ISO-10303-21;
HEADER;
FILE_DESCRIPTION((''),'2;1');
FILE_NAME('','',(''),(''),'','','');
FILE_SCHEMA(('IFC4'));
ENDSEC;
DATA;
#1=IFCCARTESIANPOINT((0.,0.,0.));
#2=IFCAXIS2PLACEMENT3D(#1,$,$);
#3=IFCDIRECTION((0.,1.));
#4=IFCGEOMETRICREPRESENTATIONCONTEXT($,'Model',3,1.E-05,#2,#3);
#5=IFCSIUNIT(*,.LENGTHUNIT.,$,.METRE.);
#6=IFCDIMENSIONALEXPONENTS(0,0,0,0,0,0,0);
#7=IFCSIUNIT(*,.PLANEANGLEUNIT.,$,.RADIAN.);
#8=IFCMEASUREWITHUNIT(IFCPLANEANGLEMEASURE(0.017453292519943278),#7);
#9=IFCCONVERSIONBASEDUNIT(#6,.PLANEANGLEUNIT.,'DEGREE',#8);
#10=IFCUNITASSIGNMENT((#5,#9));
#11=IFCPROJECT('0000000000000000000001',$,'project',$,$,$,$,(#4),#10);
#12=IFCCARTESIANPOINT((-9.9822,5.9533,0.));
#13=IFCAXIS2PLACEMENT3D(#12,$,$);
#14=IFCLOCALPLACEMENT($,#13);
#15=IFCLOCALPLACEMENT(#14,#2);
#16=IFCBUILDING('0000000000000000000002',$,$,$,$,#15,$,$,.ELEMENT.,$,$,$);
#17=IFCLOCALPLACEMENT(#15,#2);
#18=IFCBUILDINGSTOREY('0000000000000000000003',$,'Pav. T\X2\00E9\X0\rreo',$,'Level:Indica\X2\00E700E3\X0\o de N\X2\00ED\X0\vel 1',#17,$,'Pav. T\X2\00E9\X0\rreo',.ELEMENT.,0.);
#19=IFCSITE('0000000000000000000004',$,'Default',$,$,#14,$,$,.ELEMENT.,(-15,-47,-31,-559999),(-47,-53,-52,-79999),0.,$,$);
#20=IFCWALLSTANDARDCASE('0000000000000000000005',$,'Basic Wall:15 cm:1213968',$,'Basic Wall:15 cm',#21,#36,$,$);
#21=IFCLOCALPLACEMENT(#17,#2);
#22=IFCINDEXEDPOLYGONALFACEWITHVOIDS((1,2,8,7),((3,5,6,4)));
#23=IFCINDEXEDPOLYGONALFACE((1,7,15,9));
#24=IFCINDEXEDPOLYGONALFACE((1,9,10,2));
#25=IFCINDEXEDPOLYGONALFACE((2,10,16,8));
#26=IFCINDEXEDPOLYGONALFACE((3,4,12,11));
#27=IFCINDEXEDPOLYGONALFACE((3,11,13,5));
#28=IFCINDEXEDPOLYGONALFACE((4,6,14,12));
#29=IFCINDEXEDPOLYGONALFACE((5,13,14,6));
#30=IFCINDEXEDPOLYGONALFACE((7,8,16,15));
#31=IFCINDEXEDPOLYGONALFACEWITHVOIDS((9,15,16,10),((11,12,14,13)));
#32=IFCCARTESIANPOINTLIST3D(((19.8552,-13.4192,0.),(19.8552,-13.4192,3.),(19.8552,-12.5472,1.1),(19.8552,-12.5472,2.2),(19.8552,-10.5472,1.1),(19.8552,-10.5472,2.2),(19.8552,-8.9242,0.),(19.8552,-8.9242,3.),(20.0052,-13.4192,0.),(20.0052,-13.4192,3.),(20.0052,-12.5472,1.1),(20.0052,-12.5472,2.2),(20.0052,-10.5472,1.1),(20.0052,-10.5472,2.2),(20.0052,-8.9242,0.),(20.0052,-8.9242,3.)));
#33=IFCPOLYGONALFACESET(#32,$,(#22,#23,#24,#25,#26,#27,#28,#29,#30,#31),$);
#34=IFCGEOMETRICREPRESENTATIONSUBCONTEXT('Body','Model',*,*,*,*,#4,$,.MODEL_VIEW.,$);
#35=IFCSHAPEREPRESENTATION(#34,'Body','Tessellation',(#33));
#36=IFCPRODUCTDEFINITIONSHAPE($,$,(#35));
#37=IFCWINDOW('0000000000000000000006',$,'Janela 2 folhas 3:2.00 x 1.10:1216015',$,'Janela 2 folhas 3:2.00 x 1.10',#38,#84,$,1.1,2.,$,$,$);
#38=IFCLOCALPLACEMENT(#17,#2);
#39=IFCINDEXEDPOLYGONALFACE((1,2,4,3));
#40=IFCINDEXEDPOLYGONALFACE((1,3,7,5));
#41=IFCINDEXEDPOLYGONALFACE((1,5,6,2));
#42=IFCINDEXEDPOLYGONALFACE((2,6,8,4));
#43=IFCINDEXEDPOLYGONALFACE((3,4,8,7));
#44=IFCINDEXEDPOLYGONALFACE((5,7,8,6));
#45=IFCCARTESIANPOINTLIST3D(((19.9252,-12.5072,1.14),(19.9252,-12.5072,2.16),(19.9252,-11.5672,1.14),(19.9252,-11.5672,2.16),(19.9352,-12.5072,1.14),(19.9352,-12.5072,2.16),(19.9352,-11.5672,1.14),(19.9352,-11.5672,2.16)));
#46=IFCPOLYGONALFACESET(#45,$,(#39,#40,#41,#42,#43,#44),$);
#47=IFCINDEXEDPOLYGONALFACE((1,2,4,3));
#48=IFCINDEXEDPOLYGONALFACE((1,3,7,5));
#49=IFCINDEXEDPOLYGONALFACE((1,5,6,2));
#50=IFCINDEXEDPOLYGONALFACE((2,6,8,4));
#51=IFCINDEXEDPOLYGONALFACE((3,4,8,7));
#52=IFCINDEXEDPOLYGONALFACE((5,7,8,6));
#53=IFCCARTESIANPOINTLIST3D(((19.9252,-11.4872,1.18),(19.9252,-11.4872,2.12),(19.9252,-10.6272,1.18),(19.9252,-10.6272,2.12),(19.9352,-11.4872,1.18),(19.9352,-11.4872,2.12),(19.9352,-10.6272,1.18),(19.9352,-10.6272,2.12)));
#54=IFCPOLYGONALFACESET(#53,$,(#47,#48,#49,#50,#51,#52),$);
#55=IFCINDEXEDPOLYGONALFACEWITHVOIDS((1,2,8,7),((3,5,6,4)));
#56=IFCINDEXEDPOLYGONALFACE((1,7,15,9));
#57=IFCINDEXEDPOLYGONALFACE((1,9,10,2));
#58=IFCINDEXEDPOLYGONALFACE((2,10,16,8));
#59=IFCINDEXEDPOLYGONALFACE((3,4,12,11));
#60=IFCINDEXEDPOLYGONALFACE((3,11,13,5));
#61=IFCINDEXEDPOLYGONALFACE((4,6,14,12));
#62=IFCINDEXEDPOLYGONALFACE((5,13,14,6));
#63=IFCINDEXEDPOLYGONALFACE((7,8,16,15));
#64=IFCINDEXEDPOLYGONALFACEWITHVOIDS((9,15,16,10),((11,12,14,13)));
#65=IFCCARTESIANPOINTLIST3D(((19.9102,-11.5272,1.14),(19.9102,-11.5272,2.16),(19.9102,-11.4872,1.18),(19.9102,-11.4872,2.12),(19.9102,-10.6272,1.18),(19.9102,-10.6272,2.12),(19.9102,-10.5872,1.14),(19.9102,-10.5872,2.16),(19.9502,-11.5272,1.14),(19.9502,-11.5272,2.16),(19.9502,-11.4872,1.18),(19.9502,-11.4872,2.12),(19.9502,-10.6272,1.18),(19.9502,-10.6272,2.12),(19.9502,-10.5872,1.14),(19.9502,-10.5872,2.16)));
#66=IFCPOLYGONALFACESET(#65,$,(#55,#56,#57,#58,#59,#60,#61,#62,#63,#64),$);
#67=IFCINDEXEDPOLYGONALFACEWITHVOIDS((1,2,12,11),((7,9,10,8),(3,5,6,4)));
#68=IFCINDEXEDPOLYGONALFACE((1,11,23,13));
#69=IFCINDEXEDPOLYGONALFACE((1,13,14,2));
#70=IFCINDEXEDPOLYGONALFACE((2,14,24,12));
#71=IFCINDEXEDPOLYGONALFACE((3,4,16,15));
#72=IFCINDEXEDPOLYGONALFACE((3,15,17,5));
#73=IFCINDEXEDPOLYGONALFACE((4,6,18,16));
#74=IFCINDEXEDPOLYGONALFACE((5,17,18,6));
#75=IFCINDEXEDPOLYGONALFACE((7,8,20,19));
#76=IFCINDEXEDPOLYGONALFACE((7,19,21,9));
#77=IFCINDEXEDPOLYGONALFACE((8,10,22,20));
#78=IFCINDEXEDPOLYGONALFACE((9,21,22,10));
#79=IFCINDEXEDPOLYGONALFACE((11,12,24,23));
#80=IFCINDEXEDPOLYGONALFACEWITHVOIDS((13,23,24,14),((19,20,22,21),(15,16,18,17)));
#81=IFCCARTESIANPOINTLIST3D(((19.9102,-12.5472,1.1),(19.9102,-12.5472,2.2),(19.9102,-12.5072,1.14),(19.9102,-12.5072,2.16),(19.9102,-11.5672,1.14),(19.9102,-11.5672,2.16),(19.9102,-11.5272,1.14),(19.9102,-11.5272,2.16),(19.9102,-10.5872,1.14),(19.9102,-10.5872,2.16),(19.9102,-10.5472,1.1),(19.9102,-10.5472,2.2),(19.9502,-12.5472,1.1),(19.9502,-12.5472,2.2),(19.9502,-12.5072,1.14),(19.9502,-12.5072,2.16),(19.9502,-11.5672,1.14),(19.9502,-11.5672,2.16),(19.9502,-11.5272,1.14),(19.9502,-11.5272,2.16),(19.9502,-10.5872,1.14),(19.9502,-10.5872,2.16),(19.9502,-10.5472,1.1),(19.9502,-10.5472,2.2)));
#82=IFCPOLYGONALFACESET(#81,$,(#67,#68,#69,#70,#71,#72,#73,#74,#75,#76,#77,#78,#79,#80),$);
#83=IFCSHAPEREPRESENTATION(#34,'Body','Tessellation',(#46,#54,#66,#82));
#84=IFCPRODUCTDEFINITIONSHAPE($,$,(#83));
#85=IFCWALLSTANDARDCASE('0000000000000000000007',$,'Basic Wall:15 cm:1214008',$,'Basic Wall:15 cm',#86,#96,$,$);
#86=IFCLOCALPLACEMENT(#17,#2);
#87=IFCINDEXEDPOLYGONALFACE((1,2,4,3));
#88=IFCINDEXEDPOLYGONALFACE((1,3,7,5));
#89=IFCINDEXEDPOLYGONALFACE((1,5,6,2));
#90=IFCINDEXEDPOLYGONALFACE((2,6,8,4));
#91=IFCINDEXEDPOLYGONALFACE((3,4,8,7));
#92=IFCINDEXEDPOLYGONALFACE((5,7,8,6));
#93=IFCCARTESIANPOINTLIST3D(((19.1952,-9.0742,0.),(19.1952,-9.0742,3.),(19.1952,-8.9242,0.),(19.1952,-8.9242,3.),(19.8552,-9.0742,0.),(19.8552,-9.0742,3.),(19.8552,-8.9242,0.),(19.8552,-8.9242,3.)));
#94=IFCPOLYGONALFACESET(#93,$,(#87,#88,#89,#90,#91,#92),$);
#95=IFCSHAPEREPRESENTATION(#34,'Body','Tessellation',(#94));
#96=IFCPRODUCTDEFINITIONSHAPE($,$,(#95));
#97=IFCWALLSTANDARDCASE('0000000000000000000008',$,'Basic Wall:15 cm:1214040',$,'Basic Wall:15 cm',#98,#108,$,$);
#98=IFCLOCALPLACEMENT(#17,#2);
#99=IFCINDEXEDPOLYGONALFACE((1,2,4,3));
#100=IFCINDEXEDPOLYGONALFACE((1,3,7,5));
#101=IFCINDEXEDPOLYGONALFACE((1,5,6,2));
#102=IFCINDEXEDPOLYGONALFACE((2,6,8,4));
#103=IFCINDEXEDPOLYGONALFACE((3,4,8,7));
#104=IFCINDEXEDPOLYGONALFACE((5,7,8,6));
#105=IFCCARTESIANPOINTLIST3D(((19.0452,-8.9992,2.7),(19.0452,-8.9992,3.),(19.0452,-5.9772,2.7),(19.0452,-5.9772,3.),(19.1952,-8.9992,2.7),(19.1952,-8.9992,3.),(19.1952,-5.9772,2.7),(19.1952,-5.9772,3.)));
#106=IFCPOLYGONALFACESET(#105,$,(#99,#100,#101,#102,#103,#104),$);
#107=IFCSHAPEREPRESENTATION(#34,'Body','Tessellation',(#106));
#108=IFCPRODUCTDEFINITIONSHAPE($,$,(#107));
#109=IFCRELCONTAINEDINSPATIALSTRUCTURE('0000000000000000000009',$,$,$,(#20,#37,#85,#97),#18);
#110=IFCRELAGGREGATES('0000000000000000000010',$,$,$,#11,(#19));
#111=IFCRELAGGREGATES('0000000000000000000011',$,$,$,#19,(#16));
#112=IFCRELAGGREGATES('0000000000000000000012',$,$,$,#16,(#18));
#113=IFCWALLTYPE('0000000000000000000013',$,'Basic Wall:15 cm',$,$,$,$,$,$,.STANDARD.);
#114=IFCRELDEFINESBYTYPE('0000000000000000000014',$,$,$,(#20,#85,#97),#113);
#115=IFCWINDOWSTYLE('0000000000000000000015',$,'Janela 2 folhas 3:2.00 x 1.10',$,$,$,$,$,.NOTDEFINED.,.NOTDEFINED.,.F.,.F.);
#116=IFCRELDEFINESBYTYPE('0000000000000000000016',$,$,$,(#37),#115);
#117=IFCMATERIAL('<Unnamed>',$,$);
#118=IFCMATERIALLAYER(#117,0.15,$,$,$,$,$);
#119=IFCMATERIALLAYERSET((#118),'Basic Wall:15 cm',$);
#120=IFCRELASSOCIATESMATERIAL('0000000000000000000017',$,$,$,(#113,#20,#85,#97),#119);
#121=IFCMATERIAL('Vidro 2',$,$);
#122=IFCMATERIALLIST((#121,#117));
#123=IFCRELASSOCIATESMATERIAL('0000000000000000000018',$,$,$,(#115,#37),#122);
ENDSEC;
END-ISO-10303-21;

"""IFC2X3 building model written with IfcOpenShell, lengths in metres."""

from ifc_helpers import new_model, entity, si_unit, converted_unit, direction, frame, frame_2d, origin, origin_2d_with_axis, place, context, subcontext, project, spatial, polyline, rectangle, outline, extrude, source, transform, mapped, material, material_list, layer, layer_set, layer_usage, type_object, type_shapes, element, fill, save


model = new_model("IFC2X3")

# Units and contexts
model_context = context("Model", 3, precision=1e-05, world=origin(), true_north=direction((0.0, 1.0)))
body_context = subcontext(model_context, "Body", "Model", "MODEL_VIEW")
ifc_project = project(units=[si_unit("LENGTHUNIT", "METRE"), converted_unit("PLANEANGLEUNIT", "DEGREE", entity("IfcPlaneAngleMeasure", 0.017453292519943278), si_unit("PLANEANGLEUNIT", "RADIAN"), dimensions=[0, 0, 0, 0, 0, 0, 0])], contexts=[model_context])

# Site, building, storey
site_placement = place(None, frame((-9.9822, 5.9533, 0.0)))
site = spatial("IfcSite", under=ifc_project, at=site_placement, Name="Default", CompositionType="ELEMENT", RefLatitude=(-15, -47, -31, -559999), RefLongitude=(-47, -53, -52, -79999), RefElevation=0.0)
building_placement = place(site_placement, origin())
building = spatial("IfcBuilding", under=site, at=building_placement, CompositionType="ELEMENT")
storey_placement = place(building_placement, origin())
storey = spatial("IfcBuildingStorey", under=building, at=storey_placement, Name="Pav. Térreo", ObjectType="Level:Indicação de Nível 1", LongName="Pav. Térreo", CompositionType="ELEMENT", Elevation=0.0)

# Shared definitions
ifc_material_1 = material(Name="<Unnamed>")

# Shared definitions
ifc_layer = layer(ifc_material_1, 0.15)
ifc_layer_set = layer_set([ifc_layer], Name="Basic Wall:15 cm")
wall_type = type_object("IfcWallType", Name="Basic Wall:15 cm", PredefinedType="STANDARD", material=ifc_layer_set)

# Wall, opening, window
ifc_layer_usage_1 = layer_usage(ifc_layer_set, "AXIS2", "NEGATIVE", 0.075)
wall_1_placement = place(storey_placement, frame((19.9302, -13.4192, 0.0), z_axis=(0.0, 0.0, 1.0), x_axis=(0.0, 1.0, 0.0)))
wall_1 = element("IfcWallStandardCase", 1, at=wall_1_placement, inside=storey, type_object=wall_type, material=ifc_layer_usage_1, Name="Basic Wall:15 cm:1213968", ObjectType="Basic Wall:15 cm", context=body_context, shape_type="SweptSolid", body=[
    extrude(rectangle(XDim=4.495, YDim=0.15, at=frame_2d((2.2475, 0.0), x_axis=(-1.0, 0.0))), origin(), (0.0, 0.0, 1.0), 3.0),
])
opening_placement = place(wall_1_placement, frame((0.872, -0.075, 1.1)))
opening = element("IfcOpeningElement", 2, at=opening_placement, cuts=wall_1, ObjectType="Opening", context=body_context, shape_type="SweptSolid", body=[
    extrude(rectangle(XDim=1.1, YDim=2.0, at=frame_2d((0.55, 1.0), x_axis=(1.0, 0.0))), frame((0.0, 0.0, 0.0), z_axis=(0.0, 1.0, 0.0), x_axis=(0.0, 0.0, 1.0)), (0.0, 0.0, 1.0), 0.15),
])
ifc_material_2 = material(Name="Vidro 2")
ifc_material_list = material_list([ifc_material_2, ifc_material_1])
window_style = type_object("IfcWindowStyle", Name="Janela 2 folhas 3:2.00 x 1.10", ConstructionType="NOTDEFINED", OperationType="NOTDEFINED", ParameterTakesPrecedence=False, Sizeable=False, material=ifc_material_list)
shared_shape_1 = source(origin(), body_context, "Body", "SweptSolid", [
    extrude(rectangle(XDim=0.01, YDim=0.94, at=origin_2d_with_axis()), frame((0.51, 0.075, 0.04), z_axis=(0.0, 0.0, 1.0), x_axis=(0.0, 1.0, 0.0)), (0.0, 0.0, 1.0), 1.02),
    extrude(rectangle(XDim=0.01, YDim=0.86, at=origin_2d_with_axis()), frame((1.49, 0.075, 0.08), z_axis=(0.0, 0.0, 1.0), x_axis=(0.0, 1.0, 0.0)), (0.0, 0.0, 1.0), 0.94),
    extrude(outline(polyline([(-0.47, -0.51), (0.47, -0.51), (0.47, 0.51), (-0.47, 0.51), (-0.47, -0.51)]), holes=[polyline([(-0.43, -0.47), (-0.43, 0.47), (0.43, 0.47), (0.43, -0.47), (-0.43, -0.47)])]), frame((1.49, 0.055, 0.55), z_axis=(0.0, 1.0, 0.0), x_axis=(1.0, 0.0, 0.0)), (0.0, 0.0, 1.0), 0.04),
    extrude(outline(polyline([(-0.55, -1.0), (0.55, -1.0), (0.55, 1.0), (-0.55, 1.0), (-0.55, -1.0)]), holes=[polyline([(0.51, -0.02), (0.51, -0.96), (-0.51, -0.96), (-0.51, -0.02), (0.51, -0.02)]), polyline([(-0.51, 0.02), (-0.51, 0.96), (0.51, 0.96), (0.51, 0.02), (-0.51, 0.02)])]), frame((1.0, 0.055, 0.55), z_axis=(0.0, 1.0, 0.0), x_axis=(0.0, 0.0, -1.0)), (0.0, 0.0, 1.0), 0.04),
])
type_shapes(window_style, [shared_shape_1])
window_placement = place(opening_placement, origin())
window = element("IfcWindow", 3, at=window_placement, inside=storey, type_object=window_style, material=ifc_material_list, Name="Janela 2 folhas 3:2.00 x 1.10:1216015", ObjectType="Janela 2 folhas 3:2.00 x 1.10", OverallHeight=1.1, OverallWidth=2.0, context=body_context, shape_type="MappedRepresentation", body=[
    mapped(shared_shape_1, transform((0.0, 0.0, 0.0), scale=1.0)),
])
fill(opening, window)

# Walls
ifc_layer_usage_2 = layer_usage(ifc_layer_set, "AXIS2", "NEGATIVE", 0.075)
wall_2_placement = place(storey_placement, frame((19.8552, -8.9992, 0.0), z_axis=(0.0, 0.0, 1.0), x_axis=(-1.0, 0.0, 0.0)))
element("IfcWallStandardCase", 4, at=wall_2_placement, inside=storey, type_object=wall_type, material=ifc_layer_usage_2, Name="Basic Wall:15 cm:1214008", ObjectType="Basic Wall:15 cm", context=body_context, shape_type="SweptSolid", body=[
    extrude(rectangle(XDim=0.66, YDim=0.15, at=frame_2d((0.33, 0.0), x_axis=(-1.0, 0.0))), origin(), (0.0, 0.0, 1.0), 3.0),
])
ifc_layer_usage_3 = layer_usage(ifc_layer_set, "AXIS2", "NEGATIVE", 0.075)
wall_3_placement = place(storey_placement, frame((19.1202, -5.9772, 2.7), z_axis=(0.0, 0.0, 1.0), x_axis=(0.0, -1.0, 0.0)))
element("IfcWallStandardCase", 5, at=wall_3_placement, inside=storey, type_object=wall_type, material=ifc_layer_usage_3, Name="Basic Wall:15 cm:1214040", ObjectType="Basic Wall:15 cm", context=body_context, shape_type="SweptSolid", body=[
    extrude(rectangle(XDim=3.0219, YDim=0.15, at=frame_2d((1.511, 0.0), x_axis=(-1.0, 0.0))), origin(), (0.0, 0.0, 1.0), 0.3),
])

save(model, "model.ifc")
